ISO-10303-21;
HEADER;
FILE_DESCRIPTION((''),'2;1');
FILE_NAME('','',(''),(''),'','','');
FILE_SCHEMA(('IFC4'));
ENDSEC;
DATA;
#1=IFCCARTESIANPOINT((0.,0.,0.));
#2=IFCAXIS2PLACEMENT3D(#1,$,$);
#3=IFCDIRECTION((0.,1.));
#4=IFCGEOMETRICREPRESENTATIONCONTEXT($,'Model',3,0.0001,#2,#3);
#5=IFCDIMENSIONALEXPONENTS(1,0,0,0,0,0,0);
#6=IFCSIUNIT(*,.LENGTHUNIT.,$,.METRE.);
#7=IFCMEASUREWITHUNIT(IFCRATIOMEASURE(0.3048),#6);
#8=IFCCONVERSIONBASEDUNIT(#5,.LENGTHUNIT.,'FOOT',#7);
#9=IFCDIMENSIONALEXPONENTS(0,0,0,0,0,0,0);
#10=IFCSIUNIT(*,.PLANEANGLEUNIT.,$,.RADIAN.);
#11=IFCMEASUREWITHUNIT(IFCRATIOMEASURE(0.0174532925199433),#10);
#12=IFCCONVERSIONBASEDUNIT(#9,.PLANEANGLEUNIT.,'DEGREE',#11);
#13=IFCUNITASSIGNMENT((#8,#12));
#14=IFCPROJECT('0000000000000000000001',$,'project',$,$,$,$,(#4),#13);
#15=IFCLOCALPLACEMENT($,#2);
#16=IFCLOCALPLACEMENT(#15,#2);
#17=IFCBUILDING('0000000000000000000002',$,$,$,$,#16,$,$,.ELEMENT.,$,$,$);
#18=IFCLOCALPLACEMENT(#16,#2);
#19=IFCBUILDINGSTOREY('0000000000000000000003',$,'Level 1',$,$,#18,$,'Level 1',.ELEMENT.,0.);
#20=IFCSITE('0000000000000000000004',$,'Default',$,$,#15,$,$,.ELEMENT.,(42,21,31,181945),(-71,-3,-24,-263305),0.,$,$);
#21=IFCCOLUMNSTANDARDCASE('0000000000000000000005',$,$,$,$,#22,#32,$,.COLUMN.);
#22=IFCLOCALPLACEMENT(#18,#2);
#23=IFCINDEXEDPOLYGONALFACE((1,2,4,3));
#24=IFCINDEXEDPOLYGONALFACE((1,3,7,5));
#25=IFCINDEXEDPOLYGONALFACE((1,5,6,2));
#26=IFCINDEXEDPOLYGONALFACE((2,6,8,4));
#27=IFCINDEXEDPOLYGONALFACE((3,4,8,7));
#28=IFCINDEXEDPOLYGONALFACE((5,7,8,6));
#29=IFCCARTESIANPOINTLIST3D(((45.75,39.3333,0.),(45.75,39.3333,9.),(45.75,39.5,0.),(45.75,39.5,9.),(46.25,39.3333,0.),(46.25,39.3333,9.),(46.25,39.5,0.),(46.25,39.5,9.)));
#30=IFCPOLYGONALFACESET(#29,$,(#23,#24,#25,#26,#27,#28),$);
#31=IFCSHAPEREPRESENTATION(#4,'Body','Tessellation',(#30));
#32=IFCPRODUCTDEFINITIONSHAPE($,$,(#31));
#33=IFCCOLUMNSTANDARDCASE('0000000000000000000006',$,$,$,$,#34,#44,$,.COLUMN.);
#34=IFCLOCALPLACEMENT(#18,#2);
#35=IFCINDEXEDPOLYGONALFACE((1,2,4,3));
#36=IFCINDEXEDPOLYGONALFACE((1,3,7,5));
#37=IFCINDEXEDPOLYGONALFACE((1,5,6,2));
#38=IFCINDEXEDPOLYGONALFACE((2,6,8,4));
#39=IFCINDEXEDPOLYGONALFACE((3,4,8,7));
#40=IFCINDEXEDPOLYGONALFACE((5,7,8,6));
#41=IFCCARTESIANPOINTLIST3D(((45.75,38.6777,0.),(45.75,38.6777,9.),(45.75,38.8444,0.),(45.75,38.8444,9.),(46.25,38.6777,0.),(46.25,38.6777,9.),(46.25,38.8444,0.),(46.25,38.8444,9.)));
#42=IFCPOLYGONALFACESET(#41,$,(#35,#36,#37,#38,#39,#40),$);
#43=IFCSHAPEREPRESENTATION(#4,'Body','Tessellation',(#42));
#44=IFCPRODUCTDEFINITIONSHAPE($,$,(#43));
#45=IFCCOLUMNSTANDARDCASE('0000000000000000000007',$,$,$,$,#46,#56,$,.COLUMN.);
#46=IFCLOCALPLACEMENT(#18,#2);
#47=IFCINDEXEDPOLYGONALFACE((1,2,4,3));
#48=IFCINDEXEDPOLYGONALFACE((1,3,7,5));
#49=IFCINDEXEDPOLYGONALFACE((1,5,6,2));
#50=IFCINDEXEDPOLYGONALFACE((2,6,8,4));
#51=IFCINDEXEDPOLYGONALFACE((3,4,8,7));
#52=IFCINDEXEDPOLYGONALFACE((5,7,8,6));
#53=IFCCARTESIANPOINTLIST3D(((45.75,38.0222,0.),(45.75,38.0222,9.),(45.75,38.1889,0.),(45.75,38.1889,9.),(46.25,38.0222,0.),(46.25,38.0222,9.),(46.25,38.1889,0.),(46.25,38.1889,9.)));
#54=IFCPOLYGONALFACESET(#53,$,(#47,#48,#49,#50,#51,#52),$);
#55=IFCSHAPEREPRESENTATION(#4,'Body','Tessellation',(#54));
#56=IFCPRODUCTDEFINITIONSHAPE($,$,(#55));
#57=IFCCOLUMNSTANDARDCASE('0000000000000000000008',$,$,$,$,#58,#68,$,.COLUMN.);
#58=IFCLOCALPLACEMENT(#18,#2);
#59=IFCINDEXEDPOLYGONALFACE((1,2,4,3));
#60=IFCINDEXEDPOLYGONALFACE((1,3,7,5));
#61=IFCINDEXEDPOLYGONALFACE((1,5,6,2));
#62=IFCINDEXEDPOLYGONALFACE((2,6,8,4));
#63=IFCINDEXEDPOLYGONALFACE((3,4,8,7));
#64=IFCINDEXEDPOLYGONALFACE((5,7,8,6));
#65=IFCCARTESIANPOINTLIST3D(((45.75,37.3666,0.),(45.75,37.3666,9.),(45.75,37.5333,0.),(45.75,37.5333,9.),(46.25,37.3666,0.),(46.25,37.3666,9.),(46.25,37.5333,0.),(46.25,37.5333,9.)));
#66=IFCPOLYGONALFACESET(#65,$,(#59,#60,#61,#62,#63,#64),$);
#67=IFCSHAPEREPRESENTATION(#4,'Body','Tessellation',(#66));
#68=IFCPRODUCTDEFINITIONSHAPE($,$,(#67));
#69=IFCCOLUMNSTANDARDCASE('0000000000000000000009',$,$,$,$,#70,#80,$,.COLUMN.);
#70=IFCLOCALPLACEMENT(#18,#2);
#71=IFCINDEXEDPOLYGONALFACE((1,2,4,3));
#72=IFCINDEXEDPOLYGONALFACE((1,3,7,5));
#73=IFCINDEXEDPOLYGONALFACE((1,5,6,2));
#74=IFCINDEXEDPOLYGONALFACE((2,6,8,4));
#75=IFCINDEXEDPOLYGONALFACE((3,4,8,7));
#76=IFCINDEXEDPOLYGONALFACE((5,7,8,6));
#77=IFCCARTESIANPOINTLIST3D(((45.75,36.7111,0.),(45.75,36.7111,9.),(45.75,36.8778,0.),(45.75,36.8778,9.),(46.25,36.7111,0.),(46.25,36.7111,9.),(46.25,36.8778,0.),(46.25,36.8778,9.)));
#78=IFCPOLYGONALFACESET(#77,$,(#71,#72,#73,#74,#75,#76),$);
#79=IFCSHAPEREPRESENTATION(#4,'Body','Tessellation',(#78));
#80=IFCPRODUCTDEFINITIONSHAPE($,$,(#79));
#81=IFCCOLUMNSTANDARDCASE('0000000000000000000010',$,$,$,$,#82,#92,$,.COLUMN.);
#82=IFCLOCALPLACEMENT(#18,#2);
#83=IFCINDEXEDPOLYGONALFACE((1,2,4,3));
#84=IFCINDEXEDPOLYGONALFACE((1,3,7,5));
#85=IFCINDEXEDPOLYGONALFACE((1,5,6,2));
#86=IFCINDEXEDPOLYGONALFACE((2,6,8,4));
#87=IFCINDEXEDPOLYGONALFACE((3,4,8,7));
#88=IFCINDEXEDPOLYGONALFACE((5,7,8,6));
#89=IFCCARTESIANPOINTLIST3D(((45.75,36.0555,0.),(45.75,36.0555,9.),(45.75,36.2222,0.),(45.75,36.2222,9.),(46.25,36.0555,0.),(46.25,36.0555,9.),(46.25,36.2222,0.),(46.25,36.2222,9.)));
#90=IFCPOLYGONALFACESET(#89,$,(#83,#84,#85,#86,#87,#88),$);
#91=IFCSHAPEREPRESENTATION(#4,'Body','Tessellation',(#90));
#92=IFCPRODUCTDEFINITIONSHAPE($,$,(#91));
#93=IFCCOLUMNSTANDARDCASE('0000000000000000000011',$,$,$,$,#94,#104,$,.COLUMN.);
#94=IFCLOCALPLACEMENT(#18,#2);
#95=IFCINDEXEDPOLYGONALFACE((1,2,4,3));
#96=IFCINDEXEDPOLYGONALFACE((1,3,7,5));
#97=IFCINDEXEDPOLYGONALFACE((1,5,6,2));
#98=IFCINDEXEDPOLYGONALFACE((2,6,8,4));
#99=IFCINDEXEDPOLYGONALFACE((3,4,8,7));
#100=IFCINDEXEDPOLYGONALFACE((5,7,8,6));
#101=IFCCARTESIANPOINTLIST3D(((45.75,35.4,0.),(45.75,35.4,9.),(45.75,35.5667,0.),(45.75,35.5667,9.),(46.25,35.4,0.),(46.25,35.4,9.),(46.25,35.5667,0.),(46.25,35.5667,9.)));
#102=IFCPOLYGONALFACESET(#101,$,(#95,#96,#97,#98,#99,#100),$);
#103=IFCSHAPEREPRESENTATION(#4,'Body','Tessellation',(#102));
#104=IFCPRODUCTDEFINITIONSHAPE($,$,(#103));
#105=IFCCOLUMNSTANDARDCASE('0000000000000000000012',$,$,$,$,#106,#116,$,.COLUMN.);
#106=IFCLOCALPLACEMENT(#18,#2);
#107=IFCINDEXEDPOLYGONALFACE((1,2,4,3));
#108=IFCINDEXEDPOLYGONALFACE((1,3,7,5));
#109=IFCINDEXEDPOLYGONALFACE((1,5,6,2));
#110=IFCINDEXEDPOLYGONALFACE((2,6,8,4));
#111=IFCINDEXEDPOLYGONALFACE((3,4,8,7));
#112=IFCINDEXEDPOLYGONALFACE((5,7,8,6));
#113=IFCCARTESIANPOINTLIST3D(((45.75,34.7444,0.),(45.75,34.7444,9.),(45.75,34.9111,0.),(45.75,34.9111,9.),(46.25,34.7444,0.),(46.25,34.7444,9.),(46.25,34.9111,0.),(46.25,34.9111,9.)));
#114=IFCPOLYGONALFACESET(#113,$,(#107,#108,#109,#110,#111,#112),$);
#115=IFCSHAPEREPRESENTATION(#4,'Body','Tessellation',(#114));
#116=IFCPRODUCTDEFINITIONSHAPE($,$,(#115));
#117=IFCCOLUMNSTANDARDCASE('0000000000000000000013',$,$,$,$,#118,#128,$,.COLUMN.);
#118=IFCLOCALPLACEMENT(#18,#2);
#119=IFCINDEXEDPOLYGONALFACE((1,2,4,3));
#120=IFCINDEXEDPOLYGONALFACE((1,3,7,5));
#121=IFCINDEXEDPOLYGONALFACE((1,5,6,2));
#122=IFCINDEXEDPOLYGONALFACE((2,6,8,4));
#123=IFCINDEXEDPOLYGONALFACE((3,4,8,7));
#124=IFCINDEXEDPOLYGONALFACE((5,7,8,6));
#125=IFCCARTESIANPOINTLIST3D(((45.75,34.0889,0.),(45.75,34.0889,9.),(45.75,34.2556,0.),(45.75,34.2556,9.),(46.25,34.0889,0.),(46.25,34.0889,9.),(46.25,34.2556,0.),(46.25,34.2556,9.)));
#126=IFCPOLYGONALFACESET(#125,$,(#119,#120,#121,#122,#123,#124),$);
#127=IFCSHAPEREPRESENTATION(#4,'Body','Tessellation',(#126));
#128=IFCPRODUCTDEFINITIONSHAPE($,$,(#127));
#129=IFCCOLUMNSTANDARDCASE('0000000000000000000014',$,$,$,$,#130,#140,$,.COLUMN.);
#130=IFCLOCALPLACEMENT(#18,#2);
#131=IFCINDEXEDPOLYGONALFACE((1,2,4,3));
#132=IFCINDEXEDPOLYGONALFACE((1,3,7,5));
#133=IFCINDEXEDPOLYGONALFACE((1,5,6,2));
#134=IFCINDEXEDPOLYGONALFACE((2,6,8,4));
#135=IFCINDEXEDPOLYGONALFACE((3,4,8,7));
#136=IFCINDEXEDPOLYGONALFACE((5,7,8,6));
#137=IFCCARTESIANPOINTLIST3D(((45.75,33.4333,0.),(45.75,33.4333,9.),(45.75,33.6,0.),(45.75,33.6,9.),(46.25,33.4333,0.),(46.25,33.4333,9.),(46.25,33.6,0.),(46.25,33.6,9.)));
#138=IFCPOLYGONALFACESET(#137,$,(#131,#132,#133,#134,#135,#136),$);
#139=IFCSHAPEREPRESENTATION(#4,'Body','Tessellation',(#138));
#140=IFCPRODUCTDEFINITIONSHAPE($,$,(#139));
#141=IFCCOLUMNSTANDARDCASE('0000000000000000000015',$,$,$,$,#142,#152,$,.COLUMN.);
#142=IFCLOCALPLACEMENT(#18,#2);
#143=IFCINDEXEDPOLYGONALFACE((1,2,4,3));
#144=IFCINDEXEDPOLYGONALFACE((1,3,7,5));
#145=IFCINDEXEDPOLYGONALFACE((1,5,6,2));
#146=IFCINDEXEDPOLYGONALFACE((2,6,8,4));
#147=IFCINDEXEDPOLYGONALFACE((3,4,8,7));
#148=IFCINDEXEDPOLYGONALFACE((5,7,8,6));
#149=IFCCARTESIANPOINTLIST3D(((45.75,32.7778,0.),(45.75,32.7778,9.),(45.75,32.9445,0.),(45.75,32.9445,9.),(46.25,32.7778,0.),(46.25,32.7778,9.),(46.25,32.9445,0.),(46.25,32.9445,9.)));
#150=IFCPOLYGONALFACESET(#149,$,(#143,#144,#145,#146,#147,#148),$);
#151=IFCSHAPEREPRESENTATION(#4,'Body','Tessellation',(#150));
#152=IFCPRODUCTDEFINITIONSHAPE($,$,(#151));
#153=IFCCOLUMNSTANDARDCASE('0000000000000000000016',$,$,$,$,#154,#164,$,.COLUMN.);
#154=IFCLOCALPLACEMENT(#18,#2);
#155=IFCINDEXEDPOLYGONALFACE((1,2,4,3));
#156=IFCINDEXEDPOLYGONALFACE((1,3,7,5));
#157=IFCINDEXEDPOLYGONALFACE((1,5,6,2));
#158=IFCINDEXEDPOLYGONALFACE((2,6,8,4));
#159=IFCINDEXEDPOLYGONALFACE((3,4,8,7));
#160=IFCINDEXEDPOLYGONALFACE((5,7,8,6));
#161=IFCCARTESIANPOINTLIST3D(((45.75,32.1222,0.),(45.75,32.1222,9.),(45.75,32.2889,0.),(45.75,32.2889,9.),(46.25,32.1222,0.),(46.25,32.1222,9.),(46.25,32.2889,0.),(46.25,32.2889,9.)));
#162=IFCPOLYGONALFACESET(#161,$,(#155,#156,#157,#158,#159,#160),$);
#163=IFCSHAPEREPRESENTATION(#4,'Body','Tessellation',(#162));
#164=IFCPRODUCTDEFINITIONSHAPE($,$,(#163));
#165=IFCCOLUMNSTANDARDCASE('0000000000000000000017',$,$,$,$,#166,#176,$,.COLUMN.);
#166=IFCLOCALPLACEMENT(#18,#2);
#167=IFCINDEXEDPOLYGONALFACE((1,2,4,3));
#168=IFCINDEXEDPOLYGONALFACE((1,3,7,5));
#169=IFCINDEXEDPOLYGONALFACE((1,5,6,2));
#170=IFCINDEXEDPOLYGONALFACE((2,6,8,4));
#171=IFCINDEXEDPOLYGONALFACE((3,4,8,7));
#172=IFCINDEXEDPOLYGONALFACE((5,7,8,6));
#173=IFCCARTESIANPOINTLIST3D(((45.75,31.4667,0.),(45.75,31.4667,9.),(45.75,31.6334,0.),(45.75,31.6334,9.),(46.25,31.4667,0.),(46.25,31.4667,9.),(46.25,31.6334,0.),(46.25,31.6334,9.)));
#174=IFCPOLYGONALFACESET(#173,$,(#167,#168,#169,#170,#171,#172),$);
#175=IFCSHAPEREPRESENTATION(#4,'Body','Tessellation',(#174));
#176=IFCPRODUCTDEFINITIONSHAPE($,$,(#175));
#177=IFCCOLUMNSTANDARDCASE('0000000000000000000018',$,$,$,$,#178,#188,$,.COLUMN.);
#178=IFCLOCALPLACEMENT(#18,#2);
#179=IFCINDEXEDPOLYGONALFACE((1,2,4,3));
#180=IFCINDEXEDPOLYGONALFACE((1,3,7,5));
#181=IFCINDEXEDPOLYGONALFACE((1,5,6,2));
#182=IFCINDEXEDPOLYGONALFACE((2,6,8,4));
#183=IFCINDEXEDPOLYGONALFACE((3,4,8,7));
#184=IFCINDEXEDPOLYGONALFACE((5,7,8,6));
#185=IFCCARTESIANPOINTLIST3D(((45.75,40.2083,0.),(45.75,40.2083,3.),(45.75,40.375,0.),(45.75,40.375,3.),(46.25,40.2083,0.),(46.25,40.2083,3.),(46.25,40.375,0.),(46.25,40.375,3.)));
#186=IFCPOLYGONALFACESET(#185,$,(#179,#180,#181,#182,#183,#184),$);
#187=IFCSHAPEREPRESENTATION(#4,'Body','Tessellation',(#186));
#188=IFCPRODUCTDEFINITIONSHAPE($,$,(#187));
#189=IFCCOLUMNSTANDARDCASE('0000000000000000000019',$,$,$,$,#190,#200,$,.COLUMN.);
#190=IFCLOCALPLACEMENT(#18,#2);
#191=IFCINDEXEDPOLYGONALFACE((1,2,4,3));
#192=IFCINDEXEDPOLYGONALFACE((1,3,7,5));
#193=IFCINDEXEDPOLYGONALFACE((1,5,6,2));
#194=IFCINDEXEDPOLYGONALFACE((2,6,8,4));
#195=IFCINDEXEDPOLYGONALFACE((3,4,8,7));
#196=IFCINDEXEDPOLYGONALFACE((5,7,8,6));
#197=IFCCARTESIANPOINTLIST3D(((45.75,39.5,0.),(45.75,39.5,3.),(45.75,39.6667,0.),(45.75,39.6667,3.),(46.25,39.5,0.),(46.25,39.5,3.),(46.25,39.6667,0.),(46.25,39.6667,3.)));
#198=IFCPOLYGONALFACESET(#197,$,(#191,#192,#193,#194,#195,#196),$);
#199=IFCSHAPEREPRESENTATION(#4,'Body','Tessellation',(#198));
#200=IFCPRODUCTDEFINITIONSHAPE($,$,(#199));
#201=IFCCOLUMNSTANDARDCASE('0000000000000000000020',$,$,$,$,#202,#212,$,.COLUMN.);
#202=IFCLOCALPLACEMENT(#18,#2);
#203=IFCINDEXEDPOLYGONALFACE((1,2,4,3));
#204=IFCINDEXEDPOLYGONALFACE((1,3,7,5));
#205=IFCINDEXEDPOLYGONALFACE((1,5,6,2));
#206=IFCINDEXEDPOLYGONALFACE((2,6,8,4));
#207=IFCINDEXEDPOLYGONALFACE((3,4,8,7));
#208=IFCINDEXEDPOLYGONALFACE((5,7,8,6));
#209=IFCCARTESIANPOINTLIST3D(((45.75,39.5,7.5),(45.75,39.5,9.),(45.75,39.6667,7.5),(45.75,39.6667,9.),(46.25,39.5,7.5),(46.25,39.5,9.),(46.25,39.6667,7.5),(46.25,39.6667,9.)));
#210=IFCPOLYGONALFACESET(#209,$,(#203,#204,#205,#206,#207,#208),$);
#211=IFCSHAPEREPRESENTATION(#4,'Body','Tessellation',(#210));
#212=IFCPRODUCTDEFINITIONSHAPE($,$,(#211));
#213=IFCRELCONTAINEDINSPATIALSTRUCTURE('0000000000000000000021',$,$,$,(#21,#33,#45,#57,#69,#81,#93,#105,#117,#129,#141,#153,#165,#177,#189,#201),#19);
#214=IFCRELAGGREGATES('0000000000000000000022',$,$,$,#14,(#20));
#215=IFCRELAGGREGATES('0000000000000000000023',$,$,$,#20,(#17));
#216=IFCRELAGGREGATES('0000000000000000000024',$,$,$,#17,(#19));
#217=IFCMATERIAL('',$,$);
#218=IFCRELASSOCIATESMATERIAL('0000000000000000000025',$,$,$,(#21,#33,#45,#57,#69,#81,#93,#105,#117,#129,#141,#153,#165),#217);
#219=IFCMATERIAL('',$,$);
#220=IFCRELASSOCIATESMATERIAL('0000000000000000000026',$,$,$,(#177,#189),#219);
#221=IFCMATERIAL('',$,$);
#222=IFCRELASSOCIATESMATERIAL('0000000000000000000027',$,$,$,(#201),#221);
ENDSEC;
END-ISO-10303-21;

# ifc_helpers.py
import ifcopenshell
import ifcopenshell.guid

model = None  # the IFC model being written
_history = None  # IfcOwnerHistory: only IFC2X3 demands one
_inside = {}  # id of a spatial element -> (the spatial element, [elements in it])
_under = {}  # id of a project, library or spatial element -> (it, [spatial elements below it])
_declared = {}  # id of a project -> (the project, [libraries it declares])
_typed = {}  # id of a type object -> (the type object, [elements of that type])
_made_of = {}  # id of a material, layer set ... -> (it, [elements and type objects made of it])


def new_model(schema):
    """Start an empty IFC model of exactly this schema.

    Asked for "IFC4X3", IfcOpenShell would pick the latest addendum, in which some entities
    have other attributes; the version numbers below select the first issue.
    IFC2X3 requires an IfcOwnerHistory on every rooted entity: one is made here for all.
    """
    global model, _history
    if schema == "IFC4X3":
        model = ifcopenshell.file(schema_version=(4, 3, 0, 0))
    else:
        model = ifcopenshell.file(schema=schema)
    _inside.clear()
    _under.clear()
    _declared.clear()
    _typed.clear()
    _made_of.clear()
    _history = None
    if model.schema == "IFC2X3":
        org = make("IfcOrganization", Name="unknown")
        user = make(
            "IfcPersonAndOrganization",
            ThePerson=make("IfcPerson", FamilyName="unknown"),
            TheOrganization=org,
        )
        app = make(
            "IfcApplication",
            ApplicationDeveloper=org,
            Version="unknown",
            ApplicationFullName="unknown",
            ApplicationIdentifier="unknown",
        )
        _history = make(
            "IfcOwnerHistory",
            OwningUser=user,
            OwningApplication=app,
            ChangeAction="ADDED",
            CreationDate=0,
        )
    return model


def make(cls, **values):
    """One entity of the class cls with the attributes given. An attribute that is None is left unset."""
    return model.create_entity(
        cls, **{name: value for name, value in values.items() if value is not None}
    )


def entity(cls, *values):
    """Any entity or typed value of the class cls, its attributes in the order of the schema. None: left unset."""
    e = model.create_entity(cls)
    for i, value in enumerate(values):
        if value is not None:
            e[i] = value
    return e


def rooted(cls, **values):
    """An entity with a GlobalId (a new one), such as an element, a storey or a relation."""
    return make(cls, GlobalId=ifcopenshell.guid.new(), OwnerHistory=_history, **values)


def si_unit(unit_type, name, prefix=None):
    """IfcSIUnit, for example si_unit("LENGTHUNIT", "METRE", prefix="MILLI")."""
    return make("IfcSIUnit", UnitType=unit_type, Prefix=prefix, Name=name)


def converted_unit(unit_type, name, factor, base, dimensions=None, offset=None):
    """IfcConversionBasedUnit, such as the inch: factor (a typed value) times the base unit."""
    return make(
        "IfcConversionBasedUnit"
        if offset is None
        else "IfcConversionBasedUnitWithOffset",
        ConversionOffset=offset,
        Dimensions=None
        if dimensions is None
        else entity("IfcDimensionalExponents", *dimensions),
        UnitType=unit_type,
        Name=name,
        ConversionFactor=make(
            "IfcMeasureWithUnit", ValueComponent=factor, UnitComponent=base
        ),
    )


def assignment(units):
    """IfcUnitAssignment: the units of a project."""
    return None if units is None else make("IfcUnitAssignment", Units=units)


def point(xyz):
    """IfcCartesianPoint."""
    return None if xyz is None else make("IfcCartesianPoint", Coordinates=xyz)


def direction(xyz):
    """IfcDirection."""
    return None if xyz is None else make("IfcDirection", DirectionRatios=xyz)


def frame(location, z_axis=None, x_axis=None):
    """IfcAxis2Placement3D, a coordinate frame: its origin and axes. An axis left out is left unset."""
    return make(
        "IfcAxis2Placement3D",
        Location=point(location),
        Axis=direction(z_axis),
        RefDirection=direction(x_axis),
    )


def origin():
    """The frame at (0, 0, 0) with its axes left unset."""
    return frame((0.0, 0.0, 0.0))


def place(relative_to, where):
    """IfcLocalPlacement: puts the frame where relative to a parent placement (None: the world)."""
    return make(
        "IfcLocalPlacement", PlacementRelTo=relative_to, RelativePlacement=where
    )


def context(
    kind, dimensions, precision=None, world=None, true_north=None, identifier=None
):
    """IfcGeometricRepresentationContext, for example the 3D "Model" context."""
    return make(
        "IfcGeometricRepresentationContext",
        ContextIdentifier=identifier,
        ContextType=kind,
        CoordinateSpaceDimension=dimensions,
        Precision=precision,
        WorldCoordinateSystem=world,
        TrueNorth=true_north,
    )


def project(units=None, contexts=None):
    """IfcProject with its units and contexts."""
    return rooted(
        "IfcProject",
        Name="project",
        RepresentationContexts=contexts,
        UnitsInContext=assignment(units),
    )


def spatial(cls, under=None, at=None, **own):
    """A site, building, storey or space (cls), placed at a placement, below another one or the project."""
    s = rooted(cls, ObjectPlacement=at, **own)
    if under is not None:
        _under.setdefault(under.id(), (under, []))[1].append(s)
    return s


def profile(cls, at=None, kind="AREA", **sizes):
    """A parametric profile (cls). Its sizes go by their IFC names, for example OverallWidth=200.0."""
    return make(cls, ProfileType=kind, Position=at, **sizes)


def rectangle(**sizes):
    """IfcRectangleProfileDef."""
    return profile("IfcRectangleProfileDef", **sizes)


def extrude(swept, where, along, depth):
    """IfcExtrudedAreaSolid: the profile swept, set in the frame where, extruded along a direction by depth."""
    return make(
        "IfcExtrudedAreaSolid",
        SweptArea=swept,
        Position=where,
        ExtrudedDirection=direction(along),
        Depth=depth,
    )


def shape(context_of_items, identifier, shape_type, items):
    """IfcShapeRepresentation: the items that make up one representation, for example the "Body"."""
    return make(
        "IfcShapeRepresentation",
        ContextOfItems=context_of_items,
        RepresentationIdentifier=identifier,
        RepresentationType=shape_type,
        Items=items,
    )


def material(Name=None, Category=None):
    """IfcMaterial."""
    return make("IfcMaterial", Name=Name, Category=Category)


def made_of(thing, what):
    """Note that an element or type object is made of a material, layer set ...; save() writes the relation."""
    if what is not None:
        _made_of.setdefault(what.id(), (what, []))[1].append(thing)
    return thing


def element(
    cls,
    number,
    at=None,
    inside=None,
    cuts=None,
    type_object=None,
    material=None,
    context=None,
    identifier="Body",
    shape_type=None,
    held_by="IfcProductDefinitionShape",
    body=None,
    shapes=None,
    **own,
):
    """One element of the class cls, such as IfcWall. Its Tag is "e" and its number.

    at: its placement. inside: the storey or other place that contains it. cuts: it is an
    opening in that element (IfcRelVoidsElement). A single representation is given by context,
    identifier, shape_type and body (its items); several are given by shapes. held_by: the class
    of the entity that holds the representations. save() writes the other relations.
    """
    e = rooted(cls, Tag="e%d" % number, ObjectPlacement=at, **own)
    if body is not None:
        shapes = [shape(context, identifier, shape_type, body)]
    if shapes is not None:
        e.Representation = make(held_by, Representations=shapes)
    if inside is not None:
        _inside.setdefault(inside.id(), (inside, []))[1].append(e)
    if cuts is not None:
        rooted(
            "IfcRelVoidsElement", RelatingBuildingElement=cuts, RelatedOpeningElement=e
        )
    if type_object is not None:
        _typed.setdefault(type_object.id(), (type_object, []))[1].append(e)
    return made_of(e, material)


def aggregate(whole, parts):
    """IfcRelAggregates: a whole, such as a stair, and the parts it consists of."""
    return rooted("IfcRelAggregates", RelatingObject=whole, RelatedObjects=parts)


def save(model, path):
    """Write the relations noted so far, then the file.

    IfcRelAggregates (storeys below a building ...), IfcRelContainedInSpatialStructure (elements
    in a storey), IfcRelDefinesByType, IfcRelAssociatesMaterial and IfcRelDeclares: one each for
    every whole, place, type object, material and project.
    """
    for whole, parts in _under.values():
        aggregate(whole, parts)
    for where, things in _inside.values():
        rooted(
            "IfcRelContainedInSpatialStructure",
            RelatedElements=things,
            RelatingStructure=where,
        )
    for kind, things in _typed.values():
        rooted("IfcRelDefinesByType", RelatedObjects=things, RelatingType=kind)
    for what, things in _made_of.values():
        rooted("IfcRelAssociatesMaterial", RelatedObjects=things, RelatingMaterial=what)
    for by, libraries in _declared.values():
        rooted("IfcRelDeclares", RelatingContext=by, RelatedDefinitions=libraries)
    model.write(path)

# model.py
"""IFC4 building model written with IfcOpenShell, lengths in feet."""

from ifc_helpers import new_model, entity, si_unit, converted_unit, direction, frame, origin, place, context, project, spatial, rectangle, extrude, material, element, save


model = new_model("IFC4")

# Units and contexts
model_context = context("Model", 3, precision=0.0001, world=origin(), true_north=direction((0.0, 1.0)))
ifc_project = project(units=[converted_unit("LENGTHUNIT", "FOOT", entity("IfcRatioMeasure", 0.3048), si_unit("LENGTHUNIT", "METRE"), dimensions=[1, 0, 0, 0, 0, 0, 0]), converted_unit("PLANEANGLEUNIT", "DEGREE", entity("IfcRatioMeasure", 0.0174532925199433), si_unit("PLANEANGLEUNIT", "RADIAN"), dimensions=[0, 0, 0, 0, 0, 0, 0])], contexts=[model_context])

# Site, building, storey
site_placement = place(None, origin())
site = spatial("IfcSite", under=ifc_project, at=site_placement, Name="Default", CompositionType="ELEMENT", RefLatitude=(42, 21, 31, 181945), RefLongitude=(-71, -3, -24, -263305), RefElevation=0.0)
building_placement = place(site_placement, origin())
building = spatial("IfcBuilding", under=site, at=building_placement, CompositionType="ELEMENT")
storey_placement = place(building_placement, origin())
storey = spatial("IfcBuildingStorey", under=building, at=storey_placement, Name="Level 1", LongName="Level 1", CompositionType="ELEMENT", Elevation=0.0)

# Columns
ifc_material_1 = material(Name="")
placement_1 = place(storey_placement, frame((46.0, 46.25, 0.0), z_axis=(0.0, 0.0, 1.0), x_axis=(0.0, -1.0, 0.0)))
for number, where, z_axis, x_axis in (
    (1, (6.8334, 0.0, 0.0), (0.0, 0.0, 1.0), (1.0, 0.0, 0.0)),
    (2, (7.4889, 0.0, 0.0), (0.0, 0.0, 1.0), (1.0, 0.0, 0.0)),
    (3, (8.1445, 0.0, 0.0), (0.0, 0.0, 1.0), (1.0, 0.0, 0.0)),
    (4, (8.8, 0.0, 0.0), (0.0, 0.0, 1.0), (1.0, 0.0, 0.0)),
    (5, (9.4556, 0.0, 0.0), (0.0, 0.0, 1.0), (1.0, 0.0, 0.0)),
    (6, (10.1111, 0.0, 0.0), (0.0, 0.0, 1.0), (1.0, 0.0, 0.0)),
    (7, (10.7667, 0.0, 0.0), (0.0, 0.0, 1.0), (1.0, 0.0, 0.0)),
    (8, (11.4222, 0.0, 0.0), (0.0, 0.0, 1.0), (1.0, 0.0, 0.0)),
    (9, (12.0778, 0.0, 0.0), (0.0, 0.0, 1.0), (1.0, 0.0, 0.0)),
    (10, (12.7333, 0.0, 0.0), (0.0, 0.0, 1.0), (1.0, 0.0, 0.0)),
    (11, (13.3889, 0.0, 0.0), (0.0, 0.0, 1.0), (1.0, 0.0, 0.0)),
    (12, (14.0444, 0.0, 0.0), (0.0, 0.0, 1.0), (1.0, 0.0, 0.0)),
    (13, (14.7, 0.0, 0.0), (0.0, 0.0, 1.0), (1.0, 0.0, 0.0)),
):
    element("IfcColumnStandardCase", number, at=place(placement_1, frame(where, z_axis=z_axis, x_axis=x_axis)), inside=storey, material=ifc_material_1, PredefinedType="COLUMN", context=model_context, shape_type="SweptSolid", body=[
        extrude(rectangle(XDim=0.1667, YDim=0.5), origin(), (0.0, 0.0, 1.0), 9.0),
    ])
ifc_material_2 = material(Name="")
for number, where, z_axis, x_axis in (
    (14, (5.9583, 0.0, 0.0), (0.0, 0.0, 1.0), (1.0, 0.0, 0.0)),
    (15, (6.6667, 0.0, 0.0), (0.0, 0.0, 1.0), (1.0, 0.0, 0.0)),
):
    element("IfcColumnStandardCase", number, at=place(placement_1, frame(where, z_axis=z_axis, x_axis=x_axis)), inside=storey, material=ifc_material_2, PredefinedType="COLUMN", context=model_context, shape_type="SweptSolid", body=[
        extrude(rectangle(XDim=0.1667, YDim=0.5), origin(), (0.0, 0.0, 1.0), 3.0),
    ])
ifc_material_3 = material(Name="")
for number, where, z_axis, x_axis in (
    (16, (6.6667, 0.0, 7.5), (0.0, 0.0, 1.0), (1.0, 0.0, 0.0)),
):
    element("IfcColumnStandardCase", number, at=place(placement_1, frame(where, z_axis=z_axis, x_axis=x_axis)), inside=storey, material=ifc_material_3, PredefinedType="COLUMN", context=model_context, shape_type="SweptSolid", body=[
        extrude(rectangle(XDim=0.1667, YDim=0.5), origin(), (0.0, 0.0, 1.0), 1.5),
    ])

save(model, "model.ifc")
